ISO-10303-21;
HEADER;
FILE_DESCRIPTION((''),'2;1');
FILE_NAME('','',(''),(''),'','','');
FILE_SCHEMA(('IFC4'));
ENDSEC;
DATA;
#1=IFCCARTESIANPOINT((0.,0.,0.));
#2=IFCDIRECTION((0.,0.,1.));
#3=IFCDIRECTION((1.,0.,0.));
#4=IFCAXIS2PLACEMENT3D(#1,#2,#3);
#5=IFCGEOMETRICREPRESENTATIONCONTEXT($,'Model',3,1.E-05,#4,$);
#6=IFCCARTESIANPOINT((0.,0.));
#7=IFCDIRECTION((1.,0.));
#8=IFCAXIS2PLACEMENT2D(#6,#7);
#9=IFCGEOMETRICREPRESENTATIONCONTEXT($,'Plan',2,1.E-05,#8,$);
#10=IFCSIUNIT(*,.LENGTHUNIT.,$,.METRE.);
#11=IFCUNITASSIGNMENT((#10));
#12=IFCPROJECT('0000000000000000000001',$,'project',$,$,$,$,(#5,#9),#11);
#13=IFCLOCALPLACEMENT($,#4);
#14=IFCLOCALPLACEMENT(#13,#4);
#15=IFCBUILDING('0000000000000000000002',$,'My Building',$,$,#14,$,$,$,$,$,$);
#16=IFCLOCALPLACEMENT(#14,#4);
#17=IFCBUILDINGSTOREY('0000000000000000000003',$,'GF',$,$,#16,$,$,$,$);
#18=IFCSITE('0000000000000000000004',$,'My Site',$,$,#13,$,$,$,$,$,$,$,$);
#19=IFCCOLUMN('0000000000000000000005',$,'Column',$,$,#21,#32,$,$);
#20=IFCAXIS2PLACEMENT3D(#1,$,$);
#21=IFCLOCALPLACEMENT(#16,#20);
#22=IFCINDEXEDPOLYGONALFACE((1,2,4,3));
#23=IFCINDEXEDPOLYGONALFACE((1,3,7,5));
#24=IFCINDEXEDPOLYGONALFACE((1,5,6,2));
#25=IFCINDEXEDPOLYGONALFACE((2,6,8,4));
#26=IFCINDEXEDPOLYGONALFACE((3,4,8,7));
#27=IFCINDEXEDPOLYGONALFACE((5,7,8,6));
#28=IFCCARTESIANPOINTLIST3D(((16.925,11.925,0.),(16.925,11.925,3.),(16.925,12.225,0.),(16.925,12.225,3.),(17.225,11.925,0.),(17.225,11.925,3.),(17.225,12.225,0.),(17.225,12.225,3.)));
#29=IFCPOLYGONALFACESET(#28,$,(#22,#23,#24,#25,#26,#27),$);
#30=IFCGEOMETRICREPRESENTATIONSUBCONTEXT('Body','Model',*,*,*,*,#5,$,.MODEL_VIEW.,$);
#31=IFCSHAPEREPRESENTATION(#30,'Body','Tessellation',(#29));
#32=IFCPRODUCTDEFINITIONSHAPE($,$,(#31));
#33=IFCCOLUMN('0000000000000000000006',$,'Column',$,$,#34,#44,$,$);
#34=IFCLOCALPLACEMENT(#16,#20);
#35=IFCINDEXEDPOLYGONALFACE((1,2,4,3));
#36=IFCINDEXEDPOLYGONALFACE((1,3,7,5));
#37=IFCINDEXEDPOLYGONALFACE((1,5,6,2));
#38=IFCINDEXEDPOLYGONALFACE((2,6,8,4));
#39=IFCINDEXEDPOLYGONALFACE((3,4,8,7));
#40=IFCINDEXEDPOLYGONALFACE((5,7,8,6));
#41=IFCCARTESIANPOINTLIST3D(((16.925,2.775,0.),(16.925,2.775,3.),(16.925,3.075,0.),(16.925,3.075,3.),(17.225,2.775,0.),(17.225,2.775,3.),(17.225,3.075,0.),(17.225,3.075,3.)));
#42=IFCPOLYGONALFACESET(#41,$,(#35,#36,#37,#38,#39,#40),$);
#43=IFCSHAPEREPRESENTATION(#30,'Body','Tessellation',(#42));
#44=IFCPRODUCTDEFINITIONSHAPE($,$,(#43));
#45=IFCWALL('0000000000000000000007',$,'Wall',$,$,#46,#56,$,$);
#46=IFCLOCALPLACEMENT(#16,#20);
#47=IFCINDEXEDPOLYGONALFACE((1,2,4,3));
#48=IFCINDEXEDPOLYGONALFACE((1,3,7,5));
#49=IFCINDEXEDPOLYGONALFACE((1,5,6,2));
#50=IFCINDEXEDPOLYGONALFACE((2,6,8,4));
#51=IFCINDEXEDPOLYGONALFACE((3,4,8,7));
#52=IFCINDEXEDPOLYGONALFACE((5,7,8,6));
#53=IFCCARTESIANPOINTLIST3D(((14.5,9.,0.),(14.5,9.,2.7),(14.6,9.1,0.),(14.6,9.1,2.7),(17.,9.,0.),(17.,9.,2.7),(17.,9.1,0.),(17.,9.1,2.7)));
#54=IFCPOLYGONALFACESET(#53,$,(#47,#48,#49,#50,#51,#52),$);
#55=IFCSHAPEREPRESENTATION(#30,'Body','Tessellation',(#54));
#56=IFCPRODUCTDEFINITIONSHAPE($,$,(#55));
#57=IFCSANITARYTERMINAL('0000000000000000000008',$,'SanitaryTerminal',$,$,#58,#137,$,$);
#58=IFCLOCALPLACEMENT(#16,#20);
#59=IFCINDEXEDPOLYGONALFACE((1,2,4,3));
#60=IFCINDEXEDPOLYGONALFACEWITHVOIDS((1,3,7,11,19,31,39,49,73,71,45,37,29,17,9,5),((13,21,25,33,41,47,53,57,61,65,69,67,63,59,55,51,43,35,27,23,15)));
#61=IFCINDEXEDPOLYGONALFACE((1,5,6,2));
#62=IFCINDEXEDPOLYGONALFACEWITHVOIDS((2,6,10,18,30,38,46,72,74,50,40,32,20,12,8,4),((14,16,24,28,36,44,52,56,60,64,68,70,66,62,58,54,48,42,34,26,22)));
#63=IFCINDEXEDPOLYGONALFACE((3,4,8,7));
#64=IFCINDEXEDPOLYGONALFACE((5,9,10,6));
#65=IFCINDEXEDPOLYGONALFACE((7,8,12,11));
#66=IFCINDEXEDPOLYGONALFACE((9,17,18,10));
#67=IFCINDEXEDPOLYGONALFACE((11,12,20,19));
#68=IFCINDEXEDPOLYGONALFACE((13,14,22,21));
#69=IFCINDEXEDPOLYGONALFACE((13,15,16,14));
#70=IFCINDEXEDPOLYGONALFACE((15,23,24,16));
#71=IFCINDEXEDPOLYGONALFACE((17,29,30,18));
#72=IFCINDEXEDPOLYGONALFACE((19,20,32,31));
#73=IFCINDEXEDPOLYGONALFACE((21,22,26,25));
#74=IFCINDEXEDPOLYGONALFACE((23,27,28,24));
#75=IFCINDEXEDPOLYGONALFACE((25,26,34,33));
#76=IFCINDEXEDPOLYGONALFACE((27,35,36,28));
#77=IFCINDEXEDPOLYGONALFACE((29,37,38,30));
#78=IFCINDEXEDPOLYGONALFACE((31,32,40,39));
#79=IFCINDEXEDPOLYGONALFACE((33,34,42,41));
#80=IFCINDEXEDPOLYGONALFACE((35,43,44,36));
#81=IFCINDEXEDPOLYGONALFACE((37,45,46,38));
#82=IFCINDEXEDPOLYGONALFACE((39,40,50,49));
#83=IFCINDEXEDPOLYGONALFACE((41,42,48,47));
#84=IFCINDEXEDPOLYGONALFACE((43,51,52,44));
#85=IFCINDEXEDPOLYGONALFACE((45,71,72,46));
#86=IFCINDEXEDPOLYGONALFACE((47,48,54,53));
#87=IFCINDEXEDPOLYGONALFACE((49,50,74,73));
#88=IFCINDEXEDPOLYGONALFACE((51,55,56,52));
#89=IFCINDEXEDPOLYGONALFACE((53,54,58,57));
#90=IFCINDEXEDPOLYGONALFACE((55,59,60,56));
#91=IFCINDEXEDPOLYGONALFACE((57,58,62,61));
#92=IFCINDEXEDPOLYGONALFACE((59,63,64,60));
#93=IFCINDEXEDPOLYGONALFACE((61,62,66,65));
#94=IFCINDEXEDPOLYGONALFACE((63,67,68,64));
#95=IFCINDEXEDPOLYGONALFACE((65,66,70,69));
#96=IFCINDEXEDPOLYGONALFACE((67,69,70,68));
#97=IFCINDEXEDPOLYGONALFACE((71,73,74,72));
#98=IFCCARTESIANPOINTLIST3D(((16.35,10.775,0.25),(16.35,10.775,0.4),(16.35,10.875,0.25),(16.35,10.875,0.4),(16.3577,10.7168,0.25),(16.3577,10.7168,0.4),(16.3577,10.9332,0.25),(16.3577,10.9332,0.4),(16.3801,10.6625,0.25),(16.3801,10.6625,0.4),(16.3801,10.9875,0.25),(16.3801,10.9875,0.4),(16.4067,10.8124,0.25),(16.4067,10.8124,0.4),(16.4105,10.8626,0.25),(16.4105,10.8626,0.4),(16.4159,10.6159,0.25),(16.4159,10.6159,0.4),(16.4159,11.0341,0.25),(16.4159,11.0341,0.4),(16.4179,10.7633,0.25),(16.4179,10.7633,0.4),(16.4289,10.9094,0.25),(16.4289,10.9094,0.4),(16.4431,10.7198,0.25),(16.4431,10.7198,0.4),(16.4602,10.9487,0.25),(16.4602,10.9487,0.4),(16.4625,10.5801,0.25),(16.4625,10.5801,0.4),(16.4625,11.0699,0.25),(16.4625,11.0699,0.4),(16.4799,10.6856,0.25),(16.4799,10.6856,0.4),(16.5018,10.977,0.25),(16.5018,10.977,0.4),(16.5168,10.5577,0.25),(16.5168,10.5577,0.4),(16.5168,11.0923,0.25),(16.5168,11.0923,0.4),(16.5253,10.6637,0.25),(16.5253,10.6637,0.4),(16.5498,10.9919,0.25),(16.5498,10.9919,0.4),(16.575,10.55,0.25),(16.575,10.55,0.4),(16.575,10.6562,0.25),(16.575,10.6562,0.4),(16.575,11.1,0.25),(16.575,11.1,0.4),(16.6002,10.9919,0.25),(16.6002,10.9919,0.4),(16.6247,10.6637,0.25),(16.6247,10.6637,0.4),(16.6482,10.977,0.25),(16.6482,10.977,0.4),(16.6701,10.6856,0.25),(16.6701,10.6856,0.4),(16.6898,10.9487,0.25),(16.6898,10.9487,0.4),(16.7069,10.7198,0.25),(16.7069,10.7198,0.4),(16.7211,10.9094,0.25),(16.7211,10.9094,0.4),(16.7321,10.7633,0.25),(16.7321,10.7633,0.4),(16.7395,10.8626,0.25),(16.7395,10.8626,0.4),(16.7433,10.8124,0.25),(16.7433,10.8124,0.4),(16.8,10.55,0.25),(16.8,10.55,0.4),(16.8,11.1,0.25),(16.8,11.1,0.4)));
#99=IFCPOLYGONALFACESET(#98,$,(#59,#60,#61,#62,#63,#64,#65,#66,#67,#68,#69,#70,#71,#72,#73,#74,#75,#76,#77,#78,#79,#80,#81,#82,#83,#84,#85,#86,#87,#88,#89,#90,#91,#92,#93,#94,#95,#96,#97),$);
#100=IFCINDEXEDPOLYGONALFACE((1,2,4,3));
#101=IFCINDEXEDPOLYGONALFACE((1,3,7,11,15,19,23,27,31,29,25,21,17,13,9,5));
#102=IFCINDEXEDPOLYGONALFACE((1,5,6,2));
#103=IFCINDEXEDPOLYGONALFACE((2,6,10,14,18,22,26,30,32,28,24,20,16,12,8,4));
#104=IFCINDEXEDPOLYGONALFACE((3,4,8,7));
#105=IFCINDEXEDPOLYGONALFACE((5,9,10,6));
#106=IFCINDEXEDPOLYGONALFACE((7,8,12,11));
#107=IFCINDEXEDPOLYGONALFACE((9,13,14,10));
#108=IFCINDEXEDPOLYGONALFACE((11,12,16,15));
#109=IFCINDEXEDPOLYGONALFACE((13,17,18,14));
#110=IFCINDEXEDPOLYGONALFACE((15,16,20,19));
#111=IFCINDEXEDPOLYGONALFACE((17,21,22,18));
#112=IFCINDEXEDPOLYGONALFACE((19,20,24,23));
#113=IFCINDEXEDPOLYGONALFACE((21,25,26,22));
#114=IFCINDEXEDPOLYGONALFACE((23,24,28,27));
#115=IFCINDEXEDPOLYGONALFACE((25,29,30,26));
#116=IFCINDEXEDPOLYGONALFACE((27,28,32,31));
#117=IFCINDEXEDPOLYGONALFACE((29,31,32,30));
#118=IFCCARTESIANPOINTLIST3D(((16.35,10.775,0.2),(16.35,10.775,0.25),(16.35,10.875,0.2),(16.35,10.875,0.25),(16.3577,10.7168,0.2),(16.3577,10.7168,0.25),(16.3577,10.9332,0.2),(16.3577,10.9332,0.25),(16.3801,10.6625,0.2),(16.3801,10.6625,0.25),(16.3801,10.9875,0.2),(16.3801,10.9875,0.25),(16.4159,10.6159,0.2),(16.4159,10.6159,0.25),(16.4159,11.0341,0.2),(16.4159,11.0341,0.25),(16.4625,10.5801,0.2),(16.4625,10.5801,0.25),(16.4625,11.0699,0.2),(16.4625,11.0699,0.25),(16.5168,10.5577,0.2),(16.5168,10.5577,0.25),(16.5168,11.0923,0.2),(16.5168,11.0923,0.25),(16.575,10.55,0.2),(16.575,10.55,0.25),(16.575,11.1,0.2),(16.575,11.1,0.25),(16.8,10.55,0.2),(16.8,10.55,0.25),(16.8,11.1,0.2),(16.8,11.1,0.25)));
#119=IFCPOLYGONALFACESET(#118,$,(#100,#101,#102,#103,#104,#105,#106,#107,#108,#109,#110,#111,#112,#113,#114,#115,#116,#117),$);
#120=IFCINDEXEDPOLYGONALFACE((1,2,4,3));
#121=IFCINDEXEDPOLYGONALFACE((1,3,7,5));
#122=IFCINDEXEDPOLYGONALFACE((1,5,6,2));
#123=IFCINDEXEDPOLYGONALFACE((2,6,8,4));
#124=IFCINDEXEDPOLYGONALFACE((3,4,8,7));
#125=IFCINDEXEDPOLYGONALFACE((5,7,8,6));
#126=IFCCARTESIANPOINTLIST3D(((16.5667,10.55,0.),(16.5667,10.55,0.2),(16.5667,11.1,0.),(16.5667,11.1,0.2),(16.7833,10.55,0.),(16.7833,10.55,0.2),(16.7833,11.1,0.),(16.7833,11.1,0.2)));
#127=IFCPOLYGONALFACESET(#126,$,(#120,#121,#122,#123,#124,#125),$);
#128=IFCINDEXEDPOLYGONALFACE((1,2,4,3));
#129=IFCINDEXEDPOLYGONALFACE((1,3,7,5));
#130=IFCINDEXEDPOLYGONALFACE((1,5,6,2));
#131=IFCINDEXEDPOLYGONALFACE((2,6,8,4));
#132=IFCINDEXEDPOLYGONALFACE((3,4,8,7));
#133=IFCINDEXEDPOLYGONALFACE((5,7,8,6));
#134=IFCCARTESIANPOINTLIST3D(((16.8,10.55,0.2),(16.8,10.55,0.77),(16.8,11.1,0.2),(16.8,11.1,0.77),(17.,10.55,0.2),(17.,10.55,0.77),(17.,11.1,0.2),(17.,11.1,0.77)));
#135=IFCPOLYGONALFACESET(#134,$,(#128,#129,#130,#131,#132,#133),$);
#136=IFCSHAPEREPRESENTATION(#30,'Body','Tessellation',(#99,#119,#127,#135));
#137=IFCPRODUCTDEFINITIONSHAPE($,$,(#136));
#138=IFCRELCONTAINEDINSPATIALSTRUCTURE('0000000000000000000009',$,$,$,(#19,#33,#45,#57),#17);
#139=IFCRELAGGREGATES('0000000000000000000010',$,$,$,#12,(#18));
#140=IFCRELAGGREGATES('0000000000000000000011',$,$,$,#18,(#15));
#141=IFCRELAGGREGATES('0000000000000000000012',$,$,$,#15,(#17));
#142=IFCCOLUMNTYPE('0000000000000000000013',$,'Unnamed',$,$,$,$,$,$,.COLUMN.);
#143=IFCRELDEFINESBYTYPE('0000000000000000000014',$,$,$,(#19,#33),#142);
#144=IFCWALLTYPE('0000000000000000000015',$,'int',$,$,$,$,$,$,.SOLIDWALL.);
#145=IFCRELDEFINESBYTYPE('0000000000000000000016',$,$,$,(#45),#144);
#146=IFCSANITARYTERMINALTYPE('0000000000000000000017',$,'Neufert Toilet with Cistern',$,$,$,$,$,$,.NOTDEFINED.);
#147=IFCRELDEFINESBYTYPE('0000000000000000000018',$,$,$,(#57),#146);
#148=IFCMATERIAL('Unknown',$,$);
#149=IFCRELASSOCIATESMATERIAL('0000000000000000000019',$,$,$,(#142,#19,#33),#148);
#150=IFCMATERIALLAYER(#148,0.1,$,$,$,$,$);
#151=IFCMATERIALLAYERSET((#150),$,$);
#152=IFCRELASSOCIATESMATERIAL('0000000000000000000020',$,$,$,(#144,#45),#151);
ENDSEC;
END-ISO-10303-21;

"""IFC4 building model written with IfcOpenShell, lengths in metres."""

from ifc_helpers import new_model, entity, si_unit, frame, frame_2d, origin_with_axes, origin_2d_with_axis, place, context, subcontext, project, spatial, line, arc, indexed_curve, circle_curve, rectangle, outline, extrude, shape, source, transform, mapped, material, layer, layer_set, layer_usage, material_profile, profile_set, profile_usage, type_object, type_shapes, element, save


model = new_model("IFC4")

# Units and contexts
model_context = context("Model", 3, precision=1e-05, world=origin_with_axes())
plan_context = context("Plan", 2, precision=1e-05, world=origin_2d_with_axis())
body_context_1 = subcontext(model_context, "Body", "Model", "MODEL_VIEW")
body_context_2 = subcontext(plan_context, "Body", "Plan", "PLAN_VIEW")
ifc_project = project(units=[si_unit("LENGTHUNIT", "METRE")], contexts=[model_context, plan_context])

# Site, building, storey
site_placement = place(None, origin_with_axes())
site = spatial("IfcSite", under=ifc_project, at=site_placement, Name="My Site")
building_placement = place(site_placement, origin_with_axes())
building = spatial("IfcBuilding", under=site, at=building_placement, Name="My Building")
storey_placement = place(building_placement, origin_with_axes())
storey = spatial("IfcBuildingStorey", under=building, at=storey_placement, Name="GF")

# Columns
ifc_material = material(Name="Unknown")
ifc_material_profile = material_profile(ifc_material, rectangle(XDim=0.3, YDim=0.3))
ifc_profile_set = profile_set([ifc_material_profile])
ifc_profile_usage_1 = profile_usage(ifc_profile_set, cardinal=5)
column_type = type_object("IfcColumnType", Name="Unnamed", PredefinedType="COLUMN", material=ifc_profile_set)
column_1_placement = place(storey_placement, frame((17.075, 12.075, 0.0), z_axis=(0.0, 0.0, 1.0), x_axis=(1.0, 0.0, 0.0)))
element("IfcColumn", 1, at=column_1_placement, inside=storey, type_object=column_type, material=ifc_profile_usage_1, Name="Column", context=body_context_1, shape_type="SweptSolid", body=[
    extrude(rectangle(XDim=0.3, YDim=0.3), origin_with_axes(), (0.0, 0.0, 1.0), 3.0),
])
ifc_profile_usage_2 = profile_usage(ifc_profile_set, cardinal=5)
column_2_placement = place(storey_placement, frame((17.075, 2.925, 0.0), z_axis=(0.0, 0.0, 1.0), x_axis=(1.0, 0.0, 0.0)))
element("IfcColumn", 2, at=column_2_placement, inside=storey, type_object=column_type, material=ifc_profile_usage_2, Name="Column", context=body_context_1, shape_type="SweptSolid", body=[
    extrude(rectangle(XDim=0.3, YDim=0.3), origin_with_axes(), (0.0, 0.0, 1.0), 3.0),
])

# Shared definitions
ifc_layer_1 = layer(ifc_material, 0.1)
ifc_layer_set_1 = layer_set([ifc_layer_1])
wall_type_1 = type_object("IfcWallType", Name="int", PredefinedType="SOLIDWALL", material=ifc_layer_set_1)

# Wall
ifc_layer_usage_1 = layer_usage(ifc_layer_set_1, "AXIS2", "POSITIVE", 0.0)
wall_1_placement = place(storey_placement, frame((14.5, 9.0, 0.0), z_axis=(0.0, 0.0, 1.0), x_axis=(1.0, 0.0, 0.0)))
element("IfcWall", 3, at=wall_1_placement, inside=storey, type_object=wall_type_1, material=ifc_layer_usage_1, Name="Wall", context=body_context_1, shape_type="SweptSolid", body=[
    extrude(outline(indexed_curve([(0.0, 0.0), (0.1, 0.1), (2.5, 0.1), (2.5, 0.0)], segments=[line(1, 2, 3, 4, 1)])), origin_with_axes(), (0.0, 0.0, 1.0), 2.7),
])

# Sanitary terminal
sanitary_terminal_type_1 = type_object("IfcSanitaryTerminalType", Name="Neufert Toilet with Cistern", PredefinedType="NOTDEFINED")
shared_shape_1 = source(origin_with_axes(), body_context_1, "Body", "SweptSolid", [
    extrude(outline(indexed_curve([(-0.275, -0.2), (0.275, -0.2), (0.275, -0.425), (0.2091, -0.5841), (0.05, -0.65), (-0.05, -0.65), (-0.2091, -0.5841), (-0.275, -0.425)], segments=[line(1, 2), line(2, 3), arc(3, 4, 5), line(5, 6), arc(6, 7, 8), line(8, 1)]), holes=[circle_curve(frame_2d((0.0, -0.425)), 0.1688)]), frame((0.0, 0.0, 0.25), z_axis=(0.0, 0.0, 1.0), x_axis=(1.0, 0.0, 0.0)), (0.0, 0.0, 1.0), 0.15),
    extrude(outline(indexed_curve([(-0.275, -0.2), (0.275, -0.2), (0.275, -0.425), (0.2091, -0.5841), (0.05, -0.65), (-0.05, -0.65), (-0.2091, -0.5841), (-0.275, -0.425)], segments=[line(1, 2), line(2, 3), arc(3, 4, 5), line(5, 6), arc(6, 7, 8), line(8, 1)])), frame((0.0, 0.0, 0.2), z_axis=(0.0, 0.0, 1.0), x_axis=(1.0, 0.0, 0.0)), (0.0, 0.0, 1.0), 0.05),
    extrude(outline(indexed_curve([(-0.275, -0.2167), (0.275, -0.2167), (0.275, -0.4333), (-0.275, -0.4333)], segments=[line(1, 2, 3, 4, 1)])), origin_with_axes(), (0.0, 0.0, 1.0), 0.2),
    extrude(outline(indexed_curve([(-0.275, 0.0), (0.275, 0.0), (0.275, -0.2), (-0.275, -0.2)], segments=[line(1, 2, 3, 4, 1)])), frame((0.0, 0.0, 0.2), z_axis=(0.0, 0.0, 1.0), x_axis=(1.0, 0.0, 0.0)), (0.0, 0.0, 1.0), 0.57),
])
shared_shape_2 = source(origin_with_axes(), body_context_2, "Body", "Curve2D", [
    entity("IfcIndexedPolyCurve", entity("IfcCartesianPointList2D", [[-0.275, 0.0], [0.275, 0.0], [0.275, -0.2], [-0.275, -0.2]]), [entity("IfcLineIndex", [1, 2, 3, 4, 1])]),
    entity("IfcIndexedPolyCurve", entity("IfcCartesianPointList2D", [[0.165, -0.2], [0.1925, -0.335]])),
    entity("IfcTrimmedCurve", entity("IfcEllipse", entity("IfcAxis2Placement2D", entity("IfcCartesianPoint", [0.0, -0.335]), entity("IfcDirection", [1.0, 0.0])), 0.1925, 0.315), [entity("IfcCartesianPoint", [-0.1925, -0.335])], [entity("IfcCartesianPoint", [0.1925, -0.335])], True, "CARTESIAN"),
    entity("IfcIndexedPolyCurve", entity("IfcCartesianPointList2D", [[-0.165, -0.2], [-0.1925, -0.335]])),
    entity("IfcEllipse", entity("IfcAxis2Placement2D", entity("IfcCartesianPoint", [0.0, -0.452]), entity("IfcDirection", [1.0, 0.0])), 0.1313, 0.1575),
    entity("IfcIndexedPolyCurve", entity("IfcCartesianPointList2D", [[-0.0344, -0.452], [-0.0344, -0.4295], [0.0344, -0.4295], [0.0344, -0.452]])),
    entity("IfcTrimmedCurve", entity("IfcEllipse", entity("IfcAxis2Placement2D", entity("IfcCartesianPoint", [0.0, -0.452]), entity("IfcDirection", [1.0, 0.0])), 0.0344, 0.0225), [entity("IfcCartesianPoint", [-0.0344, -0.452])], [entity("IfcCartesianPoint", [0.0344, -0.452])], True, "CARTESIAN"),
])
type_shapes(sanitary_terminal_type_1, [shared_shape_1, shared_shape_2])
for number, where, z_axis, x_axis, name in (
    (4, (17.0, 10.825, 0.0), (0.0, 0.0, 1.0), (0.0, -1.0, 0.0), "SanitaryTerminal"),
):
    element("IfcSanitaryTerminal", number, at=place(storey_placement, frame(where, z_axis=z_axis, x_axis=x_axis)), inside=storey, type_object=sanitary_terminal_type_1, Name=name, shapes=[
        shape(body_context_1, "Body", "MappedRepresentation", [mapped(shared_shape_1, transform((0.0, 0.0, 0.0), x_axis=(1.0, 0.0, 0.0), y_axis=(0.0, 1.0, 0.0), z_axis=(0.0, 0.0, 1.0), scale=1.0))]),
        shape(body_context_2, "Body", "MappedRepresentation", [mapped(shared_shape_2, transform((0.0, 0.0, 0.0), x_axis=(1.0, 0.0, 0.0), y_axis=(0.0, 1.0, 0.0), z_axis=(0.0, 0.0, 1.0), scale=1.0))]),
    ])

save(model, "model.ifc")
